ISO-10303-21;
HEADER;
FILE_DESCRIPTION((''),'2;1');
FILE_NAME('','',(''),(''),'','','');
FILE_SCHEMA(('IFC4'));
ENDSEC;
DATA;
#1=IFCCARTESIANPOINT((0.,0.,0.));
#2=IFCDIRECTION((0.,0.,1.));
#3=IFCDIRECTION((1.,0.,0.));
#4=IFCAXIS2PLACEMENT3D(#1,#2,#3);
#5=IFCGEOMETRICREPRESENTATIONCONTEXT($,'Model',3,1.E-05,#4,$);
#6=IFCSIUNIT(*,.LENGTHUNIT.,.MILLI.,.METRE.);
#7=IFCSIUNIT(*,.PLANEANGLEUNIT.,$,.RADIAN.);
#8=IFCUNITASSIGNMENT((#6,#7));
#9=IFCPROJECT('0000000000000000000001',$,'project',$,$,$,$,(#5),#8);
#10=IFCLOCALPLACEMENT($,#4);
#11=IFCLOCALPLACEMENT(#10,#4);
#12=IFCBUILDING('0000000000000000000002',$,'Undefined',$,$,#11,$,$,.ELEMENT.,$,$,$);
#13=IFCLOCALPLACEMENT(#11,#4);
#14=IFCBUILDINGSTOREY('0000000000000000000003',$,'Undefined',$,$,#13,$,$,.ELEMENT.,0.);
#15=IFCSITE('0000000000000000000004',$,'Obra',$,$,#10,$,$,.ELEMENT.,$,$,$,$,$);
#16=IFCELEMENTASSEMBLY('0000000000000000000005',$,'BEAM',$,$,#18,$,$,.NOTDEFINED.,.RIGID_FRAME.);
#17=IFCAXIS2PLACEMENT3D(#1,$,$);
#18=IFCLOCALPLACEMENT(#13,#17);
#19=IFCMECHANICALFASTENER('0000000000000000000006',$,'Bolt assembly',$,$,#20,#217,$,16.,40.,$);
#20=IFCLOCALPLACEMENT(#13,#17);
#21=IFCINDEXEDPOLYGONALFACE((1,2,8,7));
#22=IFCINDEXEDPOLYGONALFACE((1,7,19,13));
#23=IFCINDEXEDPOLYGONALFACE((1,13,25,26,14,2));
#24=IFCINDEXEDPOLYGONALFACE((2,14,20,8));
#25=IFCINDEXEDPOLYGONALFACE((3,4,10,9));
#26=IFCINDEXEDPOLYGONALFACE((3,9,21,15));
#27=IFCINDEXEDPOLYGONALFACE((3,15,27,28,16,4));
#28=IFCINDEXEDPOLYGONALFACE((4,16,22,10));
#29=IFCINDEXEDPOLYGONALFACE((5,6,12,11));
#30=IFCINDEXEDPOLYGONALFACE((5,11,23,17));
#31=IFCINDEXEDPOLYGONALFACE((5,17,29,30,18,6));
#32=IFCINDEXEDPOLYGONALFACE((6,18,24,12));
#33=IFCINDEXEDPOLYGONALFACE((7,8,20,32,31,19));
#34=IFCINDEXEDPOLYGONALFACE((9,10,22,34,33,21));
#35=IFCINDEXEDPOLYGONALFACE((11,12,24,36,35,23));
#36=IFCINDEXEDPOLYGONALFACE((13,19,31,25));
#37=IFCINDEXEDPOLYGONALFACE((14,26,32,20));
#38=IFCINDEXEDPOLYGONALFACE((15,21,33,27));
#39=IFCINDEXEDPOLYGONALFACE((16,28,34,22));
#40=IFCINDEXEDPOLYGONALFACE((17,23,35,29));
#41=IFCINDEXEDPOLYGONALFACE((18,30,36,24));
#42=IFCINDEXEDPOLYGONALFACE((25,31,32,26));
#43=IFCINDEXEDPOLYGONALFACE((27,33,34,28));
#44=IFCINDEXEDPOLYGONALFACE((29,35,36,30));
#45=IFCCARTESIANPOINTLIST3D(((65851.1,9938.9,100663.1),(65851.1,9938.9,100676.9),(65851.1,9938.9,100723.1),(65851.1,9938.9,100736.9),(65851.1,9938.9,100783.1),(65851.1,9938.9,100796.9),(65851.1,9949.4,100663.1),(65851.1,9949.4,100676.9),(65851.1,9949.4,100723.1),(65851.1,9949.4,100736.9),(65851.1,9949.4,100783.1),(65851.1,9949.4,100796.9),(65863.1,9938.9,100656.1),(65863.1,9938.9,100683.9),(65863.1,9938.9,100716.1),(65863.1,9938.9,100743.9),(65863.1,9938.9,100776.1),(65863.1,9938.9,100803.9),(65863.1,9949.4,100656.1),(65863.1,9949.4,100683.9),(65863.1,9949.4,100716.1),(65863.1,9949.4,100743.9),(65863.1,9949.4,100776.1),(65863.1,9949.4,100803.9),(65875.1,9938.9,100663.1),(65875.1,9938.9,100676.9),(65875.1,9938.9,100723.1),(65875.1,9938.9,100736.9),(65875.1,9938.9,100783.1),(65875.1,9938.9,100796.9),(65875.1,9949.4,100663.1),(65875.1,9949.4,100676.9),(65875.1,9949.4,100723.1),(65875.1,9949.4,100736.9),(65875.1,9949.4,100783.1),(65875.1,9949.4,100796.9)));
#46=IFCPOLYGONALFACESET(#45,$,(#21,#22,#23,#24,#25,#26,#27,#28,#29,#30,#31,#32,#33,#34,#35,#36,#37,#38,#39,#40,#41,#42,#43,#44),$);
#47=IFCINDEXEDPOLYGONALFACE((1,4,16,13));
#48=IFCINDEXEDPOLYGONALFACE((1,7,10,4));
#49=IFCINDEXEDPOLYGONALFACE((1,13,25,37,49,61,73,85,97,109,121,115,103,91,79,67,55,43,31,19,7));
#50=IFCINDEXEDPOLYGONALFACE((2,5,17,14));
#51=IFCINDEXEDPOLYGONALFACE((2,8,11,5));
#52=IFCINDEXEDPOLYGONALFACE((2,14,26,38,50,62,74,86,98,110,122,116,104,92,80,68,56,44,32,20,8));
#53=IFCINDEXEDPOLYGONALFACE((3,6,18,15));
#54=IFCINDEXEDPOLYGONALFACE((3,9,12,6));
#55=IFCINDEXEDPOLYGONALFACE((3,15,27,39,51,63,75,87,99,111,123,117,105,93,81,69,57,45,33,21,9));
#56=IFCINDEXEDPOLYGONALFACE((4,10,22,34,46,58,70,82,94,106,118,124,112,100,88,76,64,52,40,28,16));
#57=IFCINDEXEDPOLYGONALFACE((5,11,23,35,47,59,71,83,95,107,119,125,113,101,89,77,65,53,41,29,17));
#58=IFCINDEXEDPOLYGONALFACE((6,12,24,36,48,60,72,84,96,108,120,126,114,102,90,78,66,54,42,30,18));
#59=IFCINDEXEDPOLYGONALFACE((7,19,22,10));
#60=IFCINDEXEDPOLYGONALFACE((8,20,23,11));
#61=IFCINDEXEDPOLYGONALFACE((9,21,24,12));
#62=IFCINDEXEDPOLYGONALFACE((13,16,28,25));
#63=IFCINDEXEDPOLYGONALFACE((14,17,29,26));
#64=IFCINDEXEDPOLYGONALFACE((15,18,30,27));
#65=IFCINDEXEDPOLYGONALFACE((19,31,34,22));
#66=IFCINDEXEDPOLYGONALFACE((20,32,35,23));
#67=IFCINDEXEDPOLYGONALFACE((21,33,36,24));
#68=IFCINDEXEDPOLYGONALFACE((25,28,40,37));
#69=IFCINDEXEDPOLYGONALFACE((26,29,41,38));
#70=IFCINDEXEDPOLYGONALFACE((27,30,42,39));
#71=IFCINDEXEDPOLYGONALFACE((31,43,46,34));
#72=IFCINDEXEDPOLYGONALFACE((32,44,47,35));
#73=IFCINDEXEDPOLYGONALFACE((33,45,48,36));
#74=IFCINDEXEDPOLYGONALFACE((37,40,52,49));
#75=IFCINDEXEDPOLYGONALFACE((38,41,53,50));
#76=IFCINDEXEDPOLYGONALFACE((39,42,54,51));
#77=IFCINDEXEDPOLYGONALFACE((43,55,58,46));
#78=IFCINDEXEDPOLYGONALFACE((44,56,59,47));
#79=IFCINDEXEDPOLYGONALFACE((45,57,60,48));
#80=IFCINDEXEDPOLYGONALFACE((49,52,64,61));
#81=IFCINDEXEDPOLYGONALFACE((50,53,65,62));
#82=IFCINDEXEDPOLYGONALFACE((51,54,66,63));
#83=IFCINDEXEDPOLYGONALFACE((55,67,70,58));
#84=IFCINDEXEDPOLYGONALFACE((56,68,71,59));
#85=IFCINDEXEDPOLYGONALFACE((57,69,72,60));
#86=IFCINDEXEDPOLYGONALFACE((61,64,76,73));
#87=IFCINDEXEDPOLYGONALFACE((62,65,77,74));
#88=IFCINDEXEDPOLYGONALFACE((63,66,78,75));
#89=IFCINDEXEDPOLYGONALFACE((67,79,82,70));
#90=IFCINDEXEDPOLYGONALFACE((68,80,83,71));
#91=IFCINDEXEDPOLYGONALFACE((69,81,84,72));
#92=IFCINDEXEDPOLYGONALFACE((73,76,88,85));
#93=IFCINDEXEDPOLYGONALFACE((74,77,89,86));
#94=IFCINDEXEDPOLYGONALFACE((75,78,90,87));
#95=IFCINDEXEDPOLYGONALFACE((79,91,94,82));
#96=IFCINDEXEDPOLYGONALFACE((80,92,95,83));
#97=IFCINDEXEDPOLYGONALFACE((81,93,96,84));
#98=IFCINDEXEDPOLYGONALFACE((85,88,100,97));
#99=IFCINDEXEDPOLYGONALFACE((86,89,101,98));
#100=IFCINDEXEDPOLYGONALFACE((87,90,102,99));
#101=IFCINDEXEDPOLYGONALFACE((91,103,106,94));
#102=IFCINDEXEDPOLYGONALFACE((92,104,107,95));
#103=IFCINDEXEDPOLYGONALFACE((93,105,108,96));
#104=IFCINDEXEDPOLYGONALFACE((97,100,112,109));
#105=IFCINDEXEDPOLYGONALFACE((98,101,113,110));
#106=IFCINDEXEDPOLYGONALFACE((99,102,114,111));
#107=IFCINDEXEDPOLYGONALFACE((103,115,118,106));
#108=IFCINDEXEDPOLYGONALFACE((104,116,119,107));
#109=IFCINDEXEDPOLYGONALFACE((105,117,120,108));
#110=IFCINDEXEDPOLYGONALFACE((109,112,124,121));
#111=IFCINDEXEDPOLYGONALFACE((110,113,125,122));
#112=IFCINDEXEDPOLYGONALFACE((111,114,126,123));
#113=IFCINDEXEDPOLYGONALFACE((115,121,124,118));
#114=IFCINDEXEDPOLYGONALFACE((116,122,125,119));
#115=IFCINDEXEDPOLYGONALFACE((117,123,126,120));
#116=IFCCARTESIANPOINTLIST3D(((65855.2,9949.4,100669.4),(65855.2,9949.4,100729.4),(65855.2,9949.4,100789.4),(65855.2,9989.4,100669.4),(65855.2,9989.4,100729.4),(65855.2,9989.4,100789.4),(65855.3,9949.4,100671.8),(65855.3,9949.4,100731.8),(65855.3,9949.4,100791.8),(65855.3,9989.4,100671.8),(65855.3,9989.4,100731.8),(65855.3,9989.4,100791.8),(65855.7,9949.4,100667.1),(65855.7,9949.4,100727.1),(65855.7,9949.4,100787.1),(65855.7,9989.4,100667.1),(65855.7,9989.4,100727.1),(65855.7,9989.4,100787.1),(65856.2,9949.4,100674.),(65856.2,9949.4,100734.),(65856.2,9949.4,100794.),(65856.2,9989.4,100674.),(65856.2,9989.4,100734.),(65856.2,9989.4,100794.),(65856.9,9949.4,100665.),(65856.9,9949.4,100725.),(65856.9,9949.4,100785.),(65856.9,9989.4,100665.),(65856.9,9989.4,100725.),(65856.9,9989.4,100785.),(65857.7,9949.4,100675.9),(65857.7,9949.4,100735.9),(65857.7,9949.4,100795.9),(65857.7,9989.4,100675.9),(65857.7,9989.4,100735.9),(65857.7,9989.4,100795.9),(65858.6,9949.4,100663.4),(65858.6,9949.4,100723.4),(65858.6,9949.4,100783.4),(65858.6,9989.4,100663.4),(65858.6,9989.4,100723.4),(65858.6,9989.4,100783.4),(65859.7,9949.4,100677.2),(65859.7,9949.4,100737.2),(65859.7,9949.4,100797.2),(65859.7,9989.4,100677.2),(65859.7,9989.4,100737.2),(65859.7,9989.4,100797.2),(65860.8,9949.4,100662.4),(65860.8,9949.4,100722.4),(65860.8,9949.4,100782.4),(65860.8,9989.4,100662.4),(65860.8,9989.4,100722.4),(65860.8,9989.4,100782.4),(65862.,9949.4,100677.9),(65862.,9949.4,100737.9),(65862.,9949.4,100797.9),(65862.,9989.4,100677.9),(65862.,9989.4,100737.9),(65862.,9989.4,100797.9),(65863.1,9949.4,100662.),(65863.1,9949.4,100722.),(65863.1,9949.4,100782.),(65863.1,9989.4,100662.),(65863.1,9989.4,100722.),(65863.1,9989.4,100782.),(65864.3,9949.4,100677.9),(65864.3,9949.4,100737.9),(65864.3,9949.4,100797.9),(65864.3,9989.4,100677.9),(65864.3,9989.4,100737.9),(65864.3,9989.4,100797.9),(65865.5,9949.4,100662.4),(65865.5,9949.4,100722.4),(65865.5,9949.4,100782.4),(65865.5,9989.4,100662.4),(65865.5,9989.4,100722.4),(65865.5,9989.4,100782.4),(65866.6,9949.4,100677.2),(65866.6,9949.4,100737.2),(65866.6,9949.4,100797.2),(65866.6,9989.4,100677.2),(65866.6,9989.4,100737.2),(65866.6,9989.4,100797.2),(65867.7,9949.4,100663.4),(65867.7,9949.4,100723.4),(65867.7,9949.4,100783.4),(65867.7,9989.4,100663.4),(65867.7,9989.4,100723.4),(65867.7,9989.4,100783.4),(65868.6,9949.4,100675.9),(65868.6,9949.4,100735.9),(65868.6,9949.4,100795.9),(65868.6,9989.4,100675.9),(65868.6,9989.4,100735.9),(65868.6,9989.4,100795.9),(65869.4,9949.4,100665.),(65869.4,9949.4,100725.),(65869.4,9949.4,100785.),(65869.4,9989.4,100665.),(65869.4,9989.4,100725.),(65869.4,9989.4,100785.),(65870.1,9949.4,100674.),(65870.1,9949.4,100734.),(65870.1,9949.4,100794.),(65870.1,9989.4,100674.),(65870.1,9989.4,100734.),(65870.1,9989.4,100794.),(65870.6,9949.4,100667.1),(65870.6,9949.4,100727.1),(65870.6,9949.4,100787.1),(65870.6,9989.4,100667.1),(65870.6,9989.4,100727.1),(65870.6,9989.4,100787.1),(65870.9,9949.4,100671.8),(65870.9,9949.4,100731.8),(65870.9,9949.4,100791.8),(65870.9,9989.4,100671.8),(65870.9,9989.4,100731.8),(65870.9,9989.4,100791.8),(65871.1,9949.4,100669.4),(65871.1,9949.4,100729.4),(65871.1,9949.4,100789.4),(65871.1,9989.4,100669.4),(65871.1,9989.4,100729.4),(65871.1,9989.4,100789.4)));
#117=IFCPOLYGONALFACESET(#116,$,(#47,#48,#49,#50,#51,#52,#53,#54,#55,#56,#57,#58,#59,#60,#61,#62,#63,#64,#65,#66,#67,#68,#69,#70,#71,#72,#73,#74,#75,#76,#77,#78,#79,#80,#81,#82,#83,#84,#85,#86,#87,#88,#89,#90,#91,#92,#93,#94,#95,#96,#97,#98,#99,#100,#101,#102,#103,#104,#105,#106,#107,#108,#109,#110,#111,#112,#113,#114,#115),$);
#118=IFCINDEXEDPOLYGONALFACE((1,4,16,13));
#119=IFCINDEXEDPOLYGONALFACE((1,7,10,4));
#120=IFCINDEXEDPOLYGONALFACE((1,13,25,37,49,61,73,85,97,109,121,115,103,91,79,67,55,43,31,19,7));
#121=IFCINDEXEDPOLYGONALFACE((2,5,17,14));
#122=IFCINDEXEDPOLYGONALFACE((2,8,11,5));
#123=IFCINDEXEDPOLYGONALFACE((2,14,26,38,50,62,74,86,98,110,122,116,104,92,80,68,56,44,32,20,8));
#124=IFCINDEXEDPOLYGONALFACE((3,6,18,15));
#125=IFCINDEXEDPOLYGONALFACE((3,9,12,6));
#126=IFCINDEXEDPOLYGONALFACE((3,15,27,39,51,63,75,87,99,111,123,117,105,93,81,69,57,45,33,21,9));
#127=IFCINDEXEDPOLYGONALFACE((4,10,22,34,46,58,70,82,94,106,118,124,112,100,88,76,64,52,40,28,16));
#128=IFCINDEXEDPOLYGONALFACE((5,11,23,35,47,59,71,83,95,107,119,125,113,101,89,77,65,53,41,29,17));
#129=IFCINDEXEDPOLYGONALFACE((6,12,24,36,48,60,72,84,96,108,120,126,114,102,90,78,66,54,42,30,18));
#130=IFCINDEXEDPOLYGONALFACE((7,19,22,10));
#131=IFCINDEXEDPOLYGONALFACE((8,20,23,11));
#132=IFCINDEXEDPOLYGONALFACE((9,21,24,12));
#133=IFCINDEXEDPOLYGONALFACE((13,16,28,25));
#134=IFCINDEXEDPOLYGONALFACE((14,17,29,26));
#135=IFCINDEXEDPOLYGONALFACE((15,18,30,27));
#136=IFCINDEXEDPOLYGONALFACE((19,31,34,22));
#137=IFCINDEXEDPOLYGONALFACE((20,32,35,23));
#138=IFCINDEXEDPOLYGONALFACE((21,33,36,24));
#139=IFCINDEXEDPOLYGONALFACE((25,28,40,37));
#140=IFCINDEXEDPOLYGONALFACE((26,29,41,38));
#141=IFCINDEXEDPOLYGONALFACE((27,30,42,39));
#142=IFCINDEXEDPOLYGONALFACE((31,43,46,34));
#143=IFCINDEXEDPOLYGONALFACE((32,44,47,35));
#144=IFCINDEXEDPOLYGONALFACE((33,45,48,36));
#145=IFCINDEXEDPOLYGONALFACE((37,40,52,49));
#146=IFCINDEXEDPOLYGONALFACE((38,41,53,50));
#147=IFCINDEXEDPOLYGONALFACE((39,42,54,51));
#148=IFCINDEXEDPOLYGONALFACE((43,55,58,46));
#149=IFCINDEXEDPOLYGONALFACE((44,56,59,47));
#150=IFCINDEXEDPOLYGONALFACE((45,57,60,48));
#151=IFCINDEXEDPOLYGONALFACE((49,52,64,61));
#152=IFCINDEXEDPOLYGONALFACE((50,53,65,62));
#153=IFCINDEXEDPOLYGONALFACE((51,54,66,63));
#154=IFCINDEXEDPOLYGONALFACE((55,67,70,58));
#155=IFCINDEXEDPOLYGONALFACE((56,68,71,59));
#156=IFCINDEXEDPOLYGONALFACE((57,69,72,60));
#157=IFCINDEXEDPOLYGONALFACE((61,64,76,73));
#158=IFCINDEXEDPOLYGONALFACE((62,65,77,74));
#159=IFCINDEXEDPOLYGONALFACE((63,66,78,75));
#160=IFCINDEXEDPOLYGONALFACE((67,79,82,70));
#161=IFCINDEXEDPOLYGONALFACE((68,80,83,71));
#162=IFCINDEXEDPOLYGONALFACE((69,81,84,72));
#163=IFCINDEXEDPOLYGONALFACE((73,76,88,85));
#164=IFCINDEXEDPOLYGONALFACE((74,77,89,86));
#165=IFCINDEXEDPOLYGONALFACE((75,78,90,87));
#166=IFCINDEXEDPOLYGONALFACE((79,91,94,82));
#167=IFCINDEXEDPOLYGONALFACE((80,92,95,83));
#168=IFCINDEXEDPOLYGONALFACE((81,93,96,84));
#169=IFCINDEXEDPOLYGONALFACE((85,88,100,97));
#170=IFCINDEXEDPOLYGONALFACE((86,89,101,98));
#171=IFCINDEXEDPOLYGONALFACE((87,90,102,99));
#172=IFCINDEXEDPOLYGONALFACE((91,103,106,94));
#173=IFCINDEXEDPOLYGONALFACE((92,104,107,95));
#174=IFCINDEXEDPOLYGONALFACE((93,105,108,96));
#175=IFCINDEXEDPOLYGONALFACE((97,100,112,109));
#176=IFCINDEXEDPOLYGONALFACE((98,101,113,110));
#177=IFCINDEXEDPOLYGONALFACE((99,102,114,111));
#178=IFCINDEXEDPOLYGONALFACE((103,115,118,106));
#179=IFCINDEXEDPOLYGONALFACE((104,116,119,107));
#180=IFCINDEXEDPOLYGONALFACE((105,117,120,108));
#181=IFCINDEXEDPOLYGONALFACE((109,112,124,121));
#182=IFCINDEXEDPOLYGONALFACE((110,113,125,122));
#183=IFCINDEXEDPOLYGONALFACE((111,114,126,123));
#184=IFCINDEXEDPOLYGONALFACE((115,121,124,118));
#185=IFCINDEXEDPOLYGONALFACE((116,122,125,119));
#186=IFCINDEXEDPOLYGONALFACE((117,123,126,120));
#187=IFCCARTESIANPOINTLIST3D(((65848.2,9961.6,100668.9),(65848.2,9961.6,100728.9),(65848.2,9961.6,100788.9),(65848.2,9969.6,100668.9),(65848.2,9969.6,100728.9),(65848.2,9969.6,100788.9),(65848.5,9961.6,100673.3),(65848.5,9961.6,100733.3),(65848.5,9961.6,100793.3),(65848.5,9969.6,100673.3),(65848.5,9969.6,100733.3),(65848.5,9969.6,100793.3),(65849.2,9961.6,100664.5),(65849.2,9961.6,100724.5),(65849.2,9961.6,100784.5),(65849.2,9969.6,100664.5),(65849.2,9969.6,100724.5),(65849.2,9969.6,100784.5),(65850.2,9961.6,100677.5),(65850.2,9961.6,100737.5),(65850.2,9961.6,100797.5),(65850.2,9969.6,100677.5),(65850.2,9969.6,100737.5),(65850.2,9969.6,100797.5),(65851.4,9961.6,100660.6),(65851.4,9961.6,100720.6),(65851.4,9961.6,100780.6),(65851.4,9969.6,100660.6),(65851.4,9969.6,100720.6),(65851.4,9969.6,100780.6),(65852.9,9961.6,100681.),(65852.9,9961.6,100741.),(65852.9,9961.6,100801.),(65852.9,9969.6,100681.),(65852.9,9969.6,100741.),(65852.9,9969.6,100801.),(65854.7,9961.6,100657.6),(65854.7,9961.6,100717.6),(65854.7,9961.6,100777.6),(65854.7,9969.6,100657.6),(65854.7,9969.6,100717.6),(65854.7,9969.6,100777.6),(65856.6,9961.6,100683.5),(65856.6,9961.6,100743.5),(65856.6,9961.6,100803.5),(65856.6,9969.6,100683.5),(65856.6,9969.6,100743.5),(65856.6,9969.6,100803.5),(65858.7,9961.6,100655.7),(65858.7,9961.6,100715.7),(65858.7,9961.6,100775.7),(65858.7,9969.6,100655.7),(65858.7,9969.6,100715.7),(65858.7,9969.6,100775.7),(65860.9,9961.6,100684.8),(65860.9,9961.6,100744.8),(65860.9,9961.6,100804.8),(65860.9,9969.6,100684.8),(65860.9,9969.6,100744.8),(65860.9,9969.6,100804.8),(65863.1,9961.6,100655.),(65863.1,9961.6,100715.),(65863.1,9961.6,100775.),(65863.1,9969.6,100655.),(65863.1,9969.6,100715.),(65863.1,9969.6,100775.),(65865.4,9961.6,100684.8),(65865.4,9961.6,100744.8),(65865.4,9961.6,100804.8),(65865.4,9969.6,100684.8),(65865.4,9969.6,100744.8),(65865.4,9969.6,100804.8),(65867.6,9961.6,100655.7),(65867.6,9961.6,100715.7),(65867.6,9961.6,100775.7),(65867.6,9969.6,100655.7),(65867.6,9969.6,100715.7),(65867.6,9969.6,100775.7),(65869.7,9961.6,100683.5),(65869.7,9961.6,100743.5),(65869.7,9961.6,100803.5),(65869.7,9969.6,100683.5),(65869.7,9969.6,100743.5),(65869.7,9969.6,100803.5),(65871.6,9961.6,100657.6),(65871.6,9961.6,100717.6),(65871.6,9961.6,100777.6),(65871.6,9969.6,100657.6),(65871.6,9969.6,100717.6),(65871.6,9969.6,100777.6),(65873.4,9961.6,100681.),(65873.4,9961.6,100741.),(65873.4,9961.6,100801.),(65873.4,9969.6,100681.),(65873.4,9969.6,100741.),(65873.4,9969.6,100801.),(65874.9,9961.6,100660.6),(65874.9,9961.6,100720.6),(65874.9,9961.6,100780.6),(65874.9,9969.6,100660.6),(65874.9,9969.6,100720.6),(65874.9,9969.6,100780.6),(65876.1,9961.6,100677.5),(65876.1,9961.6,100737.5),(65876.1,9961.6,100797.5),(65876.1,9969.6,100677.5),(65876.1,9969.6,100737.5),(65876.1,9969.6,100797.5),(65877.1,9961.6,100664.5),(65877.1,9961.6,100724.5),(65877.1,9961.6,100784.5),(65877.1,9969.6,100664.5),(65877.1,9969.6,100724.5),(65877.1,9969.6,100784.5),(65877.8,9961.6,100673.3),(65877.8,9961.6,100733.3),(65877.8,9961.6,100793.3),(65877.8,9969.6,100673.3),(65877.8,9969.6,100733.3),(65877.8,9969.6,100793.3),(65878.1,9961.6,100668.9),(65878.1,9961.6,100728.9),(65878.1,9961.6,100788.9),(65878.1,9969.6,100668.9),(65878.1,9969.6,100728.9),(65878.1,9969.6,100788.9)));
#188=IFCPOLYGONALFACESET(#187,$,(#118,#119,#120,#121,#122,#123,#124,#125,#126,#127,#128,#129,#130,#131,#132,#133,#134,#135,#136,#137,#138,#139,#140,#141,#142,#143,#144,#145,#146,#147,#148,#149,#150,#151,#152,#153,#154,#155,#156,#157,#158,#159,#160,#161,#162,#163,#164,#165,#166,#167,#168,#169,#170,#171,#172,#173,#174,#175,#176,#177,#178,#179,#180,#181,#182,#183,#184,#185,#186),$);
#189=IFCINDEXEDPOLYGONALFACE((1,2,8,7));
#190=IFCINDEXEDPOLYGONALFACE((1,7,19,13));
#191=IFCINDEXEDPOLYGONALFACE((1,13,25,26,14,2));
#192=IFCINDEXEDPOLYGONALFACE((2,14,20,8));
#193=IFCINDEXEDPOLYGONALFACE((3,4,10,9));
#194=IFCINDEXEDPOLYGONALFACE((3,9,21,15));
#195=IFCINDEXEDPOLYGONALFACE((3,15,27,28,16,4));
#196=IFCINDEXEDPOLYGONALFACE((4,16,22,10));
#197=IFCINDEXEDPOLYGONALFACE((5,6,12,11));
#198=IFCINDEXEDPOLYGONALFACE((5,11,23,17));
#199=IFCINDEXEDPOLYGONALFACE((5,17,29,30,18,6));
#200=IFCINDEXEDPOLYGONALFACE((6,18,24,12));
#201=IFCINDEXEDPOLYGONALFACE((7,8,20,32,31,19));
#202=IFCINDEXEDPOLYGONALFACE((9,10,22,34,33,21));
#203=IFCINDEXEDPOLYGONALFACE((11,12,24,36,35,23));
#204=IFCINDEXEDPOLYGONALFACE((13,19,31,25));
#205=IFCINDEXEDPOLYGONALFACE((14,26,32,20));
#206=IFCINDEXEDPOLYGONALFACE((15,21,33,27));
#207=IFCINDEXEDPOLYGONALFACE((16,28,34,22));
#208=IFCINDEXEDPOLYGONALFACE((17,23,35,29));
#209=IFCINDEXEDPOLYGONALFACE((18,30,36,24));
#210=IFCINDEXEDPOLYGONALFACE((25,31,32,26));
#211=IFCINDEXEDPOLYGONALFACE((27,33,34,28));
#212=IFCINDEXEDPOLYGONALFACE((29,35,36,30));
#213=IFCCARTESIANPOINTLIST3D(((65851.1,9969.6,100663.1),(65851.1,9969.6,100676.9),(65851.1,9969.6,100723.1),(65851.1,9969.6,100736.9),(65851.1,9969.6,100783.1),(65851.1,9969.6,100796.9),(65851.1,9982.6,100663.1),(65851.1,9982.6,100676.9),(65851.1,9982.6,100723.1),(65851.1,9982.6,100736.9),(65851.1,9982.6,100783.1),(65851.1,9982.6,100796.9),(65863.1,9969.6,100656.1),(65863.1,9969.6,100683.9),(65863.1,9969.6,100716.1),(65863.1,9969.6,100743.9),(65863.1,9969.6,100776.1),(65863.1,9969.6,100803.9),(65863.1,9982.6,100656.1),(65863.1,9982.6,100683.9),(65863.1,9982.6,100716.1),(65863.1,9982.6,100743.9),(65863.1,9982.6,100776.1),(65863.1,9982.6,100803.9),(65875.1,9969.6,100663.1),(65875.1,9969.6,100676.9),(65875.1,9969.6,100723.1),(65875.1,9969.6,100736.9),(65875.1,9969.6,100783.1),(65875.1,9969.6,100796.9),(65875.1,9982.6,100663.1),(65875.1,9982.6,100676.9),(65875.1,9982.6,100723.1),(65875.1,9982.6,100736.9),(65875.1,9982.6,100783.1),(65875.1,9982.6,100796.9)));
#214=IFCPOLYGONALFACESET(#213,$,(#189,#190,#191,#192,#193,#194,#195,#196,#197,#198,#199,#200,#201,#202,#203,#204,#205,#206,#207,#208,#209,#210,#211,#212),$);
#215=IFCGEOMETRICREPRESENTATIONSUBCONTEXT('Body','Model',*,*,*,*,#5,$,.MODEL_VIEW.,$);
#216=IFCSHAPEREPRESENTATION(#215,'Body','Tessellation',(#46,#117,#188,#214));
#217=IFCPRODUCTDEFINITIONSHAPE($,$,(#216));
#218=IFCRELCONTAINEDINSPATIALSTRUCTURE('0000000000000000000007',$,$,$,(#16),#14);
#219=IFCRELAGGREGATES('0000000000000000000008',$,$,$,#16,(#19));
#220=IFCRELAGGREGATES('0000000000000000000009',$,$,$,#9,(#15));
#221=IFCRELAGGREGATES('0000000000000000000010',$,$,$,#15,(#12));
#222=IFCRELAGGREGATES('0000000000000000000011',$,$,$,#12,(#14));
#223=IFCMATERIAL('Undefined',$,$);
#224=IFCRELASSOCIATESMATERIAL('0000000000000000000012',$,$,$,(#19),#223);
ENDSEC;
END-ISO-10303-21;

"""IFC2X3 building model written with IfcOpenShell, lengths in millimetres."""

from ifc_helpers import new_model, si_unit, frame, origin_with_axes, origin_2d_with_axis, place, context, subcontext, project, spatial, polyline, circle, outline, extrude, source, transform, mapped, material, element, aggregate, save


model = new_model("IFC2X3")

# Units and contexts
model_context = context("Model", 3, precision=1e-05, world=origin_with_axes())
body_context = subcontext(model_context, "Body", "Model", "MODEL_VIEW")
ifc_project = project(units=[si_unit("LENGTHUNIT", "METRE", prefix="MILLI"), si_unit("PLANEANGLEUNIT", "RADIAN")], contexts=[model_context])

# Site, building, storey
site_placement = place(None, origin_with_axes())
site = spatial("IfcSite", under=ifc_project, at=site_placement, Name="Obra", CompositionType="ELEMENT")
building_placement = place(site_placement, origin_with_axes())
building = spatial("IfcBuilding", under=site, at=building_placement, Name="Undefined", CompositionType="ELEMENT")
storey_placement = place(building_placement, origin_with_axes())
storey = spatial("IfcBuildingStorey", under=building, at=storey_placement, Name="Undefined", CompositionType="ELEMENT", Elevation=0.0)

# Shared definitions
ifc_material_1 = material(Name="Undefined")

# Shared definitions
shared_shape_1 = source(origin_with_axes(), body_context, "Body", "SweptSolid", [
    extrude(outline(polyline([(13.9, 0.0), (6.9, 12.0), (-6.9, 12.0), (-13.9, 0.0), (-6.9, -12.0), (6.9, -12.0), (13.9, 0.0)])), frame((0.0, -19.7, 0.0), z_axis=(0.0, 1.0, 0.0), x_axis=(1.0, 0.0, 0.0)), (0.0, 0.0, 1.0), 10.6),
    extrude(circle(Radius=8.0, at=origin_2d_with_axis()), frame((0.0, -9.1, 0.0), z_axis=(0.0, 1.0, 0.0), x_axis=(1.0, 0.0, 0.0)), (0.0, 0.0, 1.0), 40.0),
    extrude(circle(Radius=15.0, at=origin_2d_with_axis()), frame((0.0, 3.1, 0.0), z_axis=(0.0, 1.0, 0.0), x_axis=(1.0, 0.0, 0.0)), (0.0, 0.0, 1.0), 8.0),
    extrude(outline(polyline([(13.9, 0.0), (6.9, 12.0), (-6.9, 12.0), (-13.9, 0.0), (-6.9, -12.0), (6.9, -12.0), (13.9, 0.0)])), frame((0.0, 11.1, 0.0), z_axis=(0.0, 1.0, 0.0), x_axis=(1.0, 0.0, 0.0)), (0.0, 0.0, 1.0), 13.0),
])

# Element assembly, mechanical fastener
assembly_1_placement = place(storey_placement, origin_with_axes())
assembly_1 = element("IfcElementAssembly", 1, at=assembly_1_placement, inside=storey, Name="BEAM", AssemblyPlace="NOTDEFINED", PredefinedType="RIGID_FRAME")
mechanical_fastener_1_placement = place(assembly_1_placement, frame((65813.1, 9958.5, 100850.0), z_axis=(1.0, 0.0, 0.0), x_axis=(0.0, 0.0, -1.0)))
mechanical_fastener_1 = element("IfcMechanicalFastener", 2, at=mechanical_fastener_1_placement, material=ifc_material_1, Name="Bolt assembly", NominalDiameter=16.0, NominalLength=40.0, context=body_context, shape_type="MappedRepresentation", body=[
    mapped(shared_shape_1, transform((60.0, 0.0, 50.0))),
    mapped(shared_shape_1, transform((120.0, 0.0, 50.0))),
    mapped(shared_shape_1, transform((180.0, 0.0, 50.0))),
])
aggregate(assembly_1, [mechanical_fastener_1])

save(model, "model.ifc")
